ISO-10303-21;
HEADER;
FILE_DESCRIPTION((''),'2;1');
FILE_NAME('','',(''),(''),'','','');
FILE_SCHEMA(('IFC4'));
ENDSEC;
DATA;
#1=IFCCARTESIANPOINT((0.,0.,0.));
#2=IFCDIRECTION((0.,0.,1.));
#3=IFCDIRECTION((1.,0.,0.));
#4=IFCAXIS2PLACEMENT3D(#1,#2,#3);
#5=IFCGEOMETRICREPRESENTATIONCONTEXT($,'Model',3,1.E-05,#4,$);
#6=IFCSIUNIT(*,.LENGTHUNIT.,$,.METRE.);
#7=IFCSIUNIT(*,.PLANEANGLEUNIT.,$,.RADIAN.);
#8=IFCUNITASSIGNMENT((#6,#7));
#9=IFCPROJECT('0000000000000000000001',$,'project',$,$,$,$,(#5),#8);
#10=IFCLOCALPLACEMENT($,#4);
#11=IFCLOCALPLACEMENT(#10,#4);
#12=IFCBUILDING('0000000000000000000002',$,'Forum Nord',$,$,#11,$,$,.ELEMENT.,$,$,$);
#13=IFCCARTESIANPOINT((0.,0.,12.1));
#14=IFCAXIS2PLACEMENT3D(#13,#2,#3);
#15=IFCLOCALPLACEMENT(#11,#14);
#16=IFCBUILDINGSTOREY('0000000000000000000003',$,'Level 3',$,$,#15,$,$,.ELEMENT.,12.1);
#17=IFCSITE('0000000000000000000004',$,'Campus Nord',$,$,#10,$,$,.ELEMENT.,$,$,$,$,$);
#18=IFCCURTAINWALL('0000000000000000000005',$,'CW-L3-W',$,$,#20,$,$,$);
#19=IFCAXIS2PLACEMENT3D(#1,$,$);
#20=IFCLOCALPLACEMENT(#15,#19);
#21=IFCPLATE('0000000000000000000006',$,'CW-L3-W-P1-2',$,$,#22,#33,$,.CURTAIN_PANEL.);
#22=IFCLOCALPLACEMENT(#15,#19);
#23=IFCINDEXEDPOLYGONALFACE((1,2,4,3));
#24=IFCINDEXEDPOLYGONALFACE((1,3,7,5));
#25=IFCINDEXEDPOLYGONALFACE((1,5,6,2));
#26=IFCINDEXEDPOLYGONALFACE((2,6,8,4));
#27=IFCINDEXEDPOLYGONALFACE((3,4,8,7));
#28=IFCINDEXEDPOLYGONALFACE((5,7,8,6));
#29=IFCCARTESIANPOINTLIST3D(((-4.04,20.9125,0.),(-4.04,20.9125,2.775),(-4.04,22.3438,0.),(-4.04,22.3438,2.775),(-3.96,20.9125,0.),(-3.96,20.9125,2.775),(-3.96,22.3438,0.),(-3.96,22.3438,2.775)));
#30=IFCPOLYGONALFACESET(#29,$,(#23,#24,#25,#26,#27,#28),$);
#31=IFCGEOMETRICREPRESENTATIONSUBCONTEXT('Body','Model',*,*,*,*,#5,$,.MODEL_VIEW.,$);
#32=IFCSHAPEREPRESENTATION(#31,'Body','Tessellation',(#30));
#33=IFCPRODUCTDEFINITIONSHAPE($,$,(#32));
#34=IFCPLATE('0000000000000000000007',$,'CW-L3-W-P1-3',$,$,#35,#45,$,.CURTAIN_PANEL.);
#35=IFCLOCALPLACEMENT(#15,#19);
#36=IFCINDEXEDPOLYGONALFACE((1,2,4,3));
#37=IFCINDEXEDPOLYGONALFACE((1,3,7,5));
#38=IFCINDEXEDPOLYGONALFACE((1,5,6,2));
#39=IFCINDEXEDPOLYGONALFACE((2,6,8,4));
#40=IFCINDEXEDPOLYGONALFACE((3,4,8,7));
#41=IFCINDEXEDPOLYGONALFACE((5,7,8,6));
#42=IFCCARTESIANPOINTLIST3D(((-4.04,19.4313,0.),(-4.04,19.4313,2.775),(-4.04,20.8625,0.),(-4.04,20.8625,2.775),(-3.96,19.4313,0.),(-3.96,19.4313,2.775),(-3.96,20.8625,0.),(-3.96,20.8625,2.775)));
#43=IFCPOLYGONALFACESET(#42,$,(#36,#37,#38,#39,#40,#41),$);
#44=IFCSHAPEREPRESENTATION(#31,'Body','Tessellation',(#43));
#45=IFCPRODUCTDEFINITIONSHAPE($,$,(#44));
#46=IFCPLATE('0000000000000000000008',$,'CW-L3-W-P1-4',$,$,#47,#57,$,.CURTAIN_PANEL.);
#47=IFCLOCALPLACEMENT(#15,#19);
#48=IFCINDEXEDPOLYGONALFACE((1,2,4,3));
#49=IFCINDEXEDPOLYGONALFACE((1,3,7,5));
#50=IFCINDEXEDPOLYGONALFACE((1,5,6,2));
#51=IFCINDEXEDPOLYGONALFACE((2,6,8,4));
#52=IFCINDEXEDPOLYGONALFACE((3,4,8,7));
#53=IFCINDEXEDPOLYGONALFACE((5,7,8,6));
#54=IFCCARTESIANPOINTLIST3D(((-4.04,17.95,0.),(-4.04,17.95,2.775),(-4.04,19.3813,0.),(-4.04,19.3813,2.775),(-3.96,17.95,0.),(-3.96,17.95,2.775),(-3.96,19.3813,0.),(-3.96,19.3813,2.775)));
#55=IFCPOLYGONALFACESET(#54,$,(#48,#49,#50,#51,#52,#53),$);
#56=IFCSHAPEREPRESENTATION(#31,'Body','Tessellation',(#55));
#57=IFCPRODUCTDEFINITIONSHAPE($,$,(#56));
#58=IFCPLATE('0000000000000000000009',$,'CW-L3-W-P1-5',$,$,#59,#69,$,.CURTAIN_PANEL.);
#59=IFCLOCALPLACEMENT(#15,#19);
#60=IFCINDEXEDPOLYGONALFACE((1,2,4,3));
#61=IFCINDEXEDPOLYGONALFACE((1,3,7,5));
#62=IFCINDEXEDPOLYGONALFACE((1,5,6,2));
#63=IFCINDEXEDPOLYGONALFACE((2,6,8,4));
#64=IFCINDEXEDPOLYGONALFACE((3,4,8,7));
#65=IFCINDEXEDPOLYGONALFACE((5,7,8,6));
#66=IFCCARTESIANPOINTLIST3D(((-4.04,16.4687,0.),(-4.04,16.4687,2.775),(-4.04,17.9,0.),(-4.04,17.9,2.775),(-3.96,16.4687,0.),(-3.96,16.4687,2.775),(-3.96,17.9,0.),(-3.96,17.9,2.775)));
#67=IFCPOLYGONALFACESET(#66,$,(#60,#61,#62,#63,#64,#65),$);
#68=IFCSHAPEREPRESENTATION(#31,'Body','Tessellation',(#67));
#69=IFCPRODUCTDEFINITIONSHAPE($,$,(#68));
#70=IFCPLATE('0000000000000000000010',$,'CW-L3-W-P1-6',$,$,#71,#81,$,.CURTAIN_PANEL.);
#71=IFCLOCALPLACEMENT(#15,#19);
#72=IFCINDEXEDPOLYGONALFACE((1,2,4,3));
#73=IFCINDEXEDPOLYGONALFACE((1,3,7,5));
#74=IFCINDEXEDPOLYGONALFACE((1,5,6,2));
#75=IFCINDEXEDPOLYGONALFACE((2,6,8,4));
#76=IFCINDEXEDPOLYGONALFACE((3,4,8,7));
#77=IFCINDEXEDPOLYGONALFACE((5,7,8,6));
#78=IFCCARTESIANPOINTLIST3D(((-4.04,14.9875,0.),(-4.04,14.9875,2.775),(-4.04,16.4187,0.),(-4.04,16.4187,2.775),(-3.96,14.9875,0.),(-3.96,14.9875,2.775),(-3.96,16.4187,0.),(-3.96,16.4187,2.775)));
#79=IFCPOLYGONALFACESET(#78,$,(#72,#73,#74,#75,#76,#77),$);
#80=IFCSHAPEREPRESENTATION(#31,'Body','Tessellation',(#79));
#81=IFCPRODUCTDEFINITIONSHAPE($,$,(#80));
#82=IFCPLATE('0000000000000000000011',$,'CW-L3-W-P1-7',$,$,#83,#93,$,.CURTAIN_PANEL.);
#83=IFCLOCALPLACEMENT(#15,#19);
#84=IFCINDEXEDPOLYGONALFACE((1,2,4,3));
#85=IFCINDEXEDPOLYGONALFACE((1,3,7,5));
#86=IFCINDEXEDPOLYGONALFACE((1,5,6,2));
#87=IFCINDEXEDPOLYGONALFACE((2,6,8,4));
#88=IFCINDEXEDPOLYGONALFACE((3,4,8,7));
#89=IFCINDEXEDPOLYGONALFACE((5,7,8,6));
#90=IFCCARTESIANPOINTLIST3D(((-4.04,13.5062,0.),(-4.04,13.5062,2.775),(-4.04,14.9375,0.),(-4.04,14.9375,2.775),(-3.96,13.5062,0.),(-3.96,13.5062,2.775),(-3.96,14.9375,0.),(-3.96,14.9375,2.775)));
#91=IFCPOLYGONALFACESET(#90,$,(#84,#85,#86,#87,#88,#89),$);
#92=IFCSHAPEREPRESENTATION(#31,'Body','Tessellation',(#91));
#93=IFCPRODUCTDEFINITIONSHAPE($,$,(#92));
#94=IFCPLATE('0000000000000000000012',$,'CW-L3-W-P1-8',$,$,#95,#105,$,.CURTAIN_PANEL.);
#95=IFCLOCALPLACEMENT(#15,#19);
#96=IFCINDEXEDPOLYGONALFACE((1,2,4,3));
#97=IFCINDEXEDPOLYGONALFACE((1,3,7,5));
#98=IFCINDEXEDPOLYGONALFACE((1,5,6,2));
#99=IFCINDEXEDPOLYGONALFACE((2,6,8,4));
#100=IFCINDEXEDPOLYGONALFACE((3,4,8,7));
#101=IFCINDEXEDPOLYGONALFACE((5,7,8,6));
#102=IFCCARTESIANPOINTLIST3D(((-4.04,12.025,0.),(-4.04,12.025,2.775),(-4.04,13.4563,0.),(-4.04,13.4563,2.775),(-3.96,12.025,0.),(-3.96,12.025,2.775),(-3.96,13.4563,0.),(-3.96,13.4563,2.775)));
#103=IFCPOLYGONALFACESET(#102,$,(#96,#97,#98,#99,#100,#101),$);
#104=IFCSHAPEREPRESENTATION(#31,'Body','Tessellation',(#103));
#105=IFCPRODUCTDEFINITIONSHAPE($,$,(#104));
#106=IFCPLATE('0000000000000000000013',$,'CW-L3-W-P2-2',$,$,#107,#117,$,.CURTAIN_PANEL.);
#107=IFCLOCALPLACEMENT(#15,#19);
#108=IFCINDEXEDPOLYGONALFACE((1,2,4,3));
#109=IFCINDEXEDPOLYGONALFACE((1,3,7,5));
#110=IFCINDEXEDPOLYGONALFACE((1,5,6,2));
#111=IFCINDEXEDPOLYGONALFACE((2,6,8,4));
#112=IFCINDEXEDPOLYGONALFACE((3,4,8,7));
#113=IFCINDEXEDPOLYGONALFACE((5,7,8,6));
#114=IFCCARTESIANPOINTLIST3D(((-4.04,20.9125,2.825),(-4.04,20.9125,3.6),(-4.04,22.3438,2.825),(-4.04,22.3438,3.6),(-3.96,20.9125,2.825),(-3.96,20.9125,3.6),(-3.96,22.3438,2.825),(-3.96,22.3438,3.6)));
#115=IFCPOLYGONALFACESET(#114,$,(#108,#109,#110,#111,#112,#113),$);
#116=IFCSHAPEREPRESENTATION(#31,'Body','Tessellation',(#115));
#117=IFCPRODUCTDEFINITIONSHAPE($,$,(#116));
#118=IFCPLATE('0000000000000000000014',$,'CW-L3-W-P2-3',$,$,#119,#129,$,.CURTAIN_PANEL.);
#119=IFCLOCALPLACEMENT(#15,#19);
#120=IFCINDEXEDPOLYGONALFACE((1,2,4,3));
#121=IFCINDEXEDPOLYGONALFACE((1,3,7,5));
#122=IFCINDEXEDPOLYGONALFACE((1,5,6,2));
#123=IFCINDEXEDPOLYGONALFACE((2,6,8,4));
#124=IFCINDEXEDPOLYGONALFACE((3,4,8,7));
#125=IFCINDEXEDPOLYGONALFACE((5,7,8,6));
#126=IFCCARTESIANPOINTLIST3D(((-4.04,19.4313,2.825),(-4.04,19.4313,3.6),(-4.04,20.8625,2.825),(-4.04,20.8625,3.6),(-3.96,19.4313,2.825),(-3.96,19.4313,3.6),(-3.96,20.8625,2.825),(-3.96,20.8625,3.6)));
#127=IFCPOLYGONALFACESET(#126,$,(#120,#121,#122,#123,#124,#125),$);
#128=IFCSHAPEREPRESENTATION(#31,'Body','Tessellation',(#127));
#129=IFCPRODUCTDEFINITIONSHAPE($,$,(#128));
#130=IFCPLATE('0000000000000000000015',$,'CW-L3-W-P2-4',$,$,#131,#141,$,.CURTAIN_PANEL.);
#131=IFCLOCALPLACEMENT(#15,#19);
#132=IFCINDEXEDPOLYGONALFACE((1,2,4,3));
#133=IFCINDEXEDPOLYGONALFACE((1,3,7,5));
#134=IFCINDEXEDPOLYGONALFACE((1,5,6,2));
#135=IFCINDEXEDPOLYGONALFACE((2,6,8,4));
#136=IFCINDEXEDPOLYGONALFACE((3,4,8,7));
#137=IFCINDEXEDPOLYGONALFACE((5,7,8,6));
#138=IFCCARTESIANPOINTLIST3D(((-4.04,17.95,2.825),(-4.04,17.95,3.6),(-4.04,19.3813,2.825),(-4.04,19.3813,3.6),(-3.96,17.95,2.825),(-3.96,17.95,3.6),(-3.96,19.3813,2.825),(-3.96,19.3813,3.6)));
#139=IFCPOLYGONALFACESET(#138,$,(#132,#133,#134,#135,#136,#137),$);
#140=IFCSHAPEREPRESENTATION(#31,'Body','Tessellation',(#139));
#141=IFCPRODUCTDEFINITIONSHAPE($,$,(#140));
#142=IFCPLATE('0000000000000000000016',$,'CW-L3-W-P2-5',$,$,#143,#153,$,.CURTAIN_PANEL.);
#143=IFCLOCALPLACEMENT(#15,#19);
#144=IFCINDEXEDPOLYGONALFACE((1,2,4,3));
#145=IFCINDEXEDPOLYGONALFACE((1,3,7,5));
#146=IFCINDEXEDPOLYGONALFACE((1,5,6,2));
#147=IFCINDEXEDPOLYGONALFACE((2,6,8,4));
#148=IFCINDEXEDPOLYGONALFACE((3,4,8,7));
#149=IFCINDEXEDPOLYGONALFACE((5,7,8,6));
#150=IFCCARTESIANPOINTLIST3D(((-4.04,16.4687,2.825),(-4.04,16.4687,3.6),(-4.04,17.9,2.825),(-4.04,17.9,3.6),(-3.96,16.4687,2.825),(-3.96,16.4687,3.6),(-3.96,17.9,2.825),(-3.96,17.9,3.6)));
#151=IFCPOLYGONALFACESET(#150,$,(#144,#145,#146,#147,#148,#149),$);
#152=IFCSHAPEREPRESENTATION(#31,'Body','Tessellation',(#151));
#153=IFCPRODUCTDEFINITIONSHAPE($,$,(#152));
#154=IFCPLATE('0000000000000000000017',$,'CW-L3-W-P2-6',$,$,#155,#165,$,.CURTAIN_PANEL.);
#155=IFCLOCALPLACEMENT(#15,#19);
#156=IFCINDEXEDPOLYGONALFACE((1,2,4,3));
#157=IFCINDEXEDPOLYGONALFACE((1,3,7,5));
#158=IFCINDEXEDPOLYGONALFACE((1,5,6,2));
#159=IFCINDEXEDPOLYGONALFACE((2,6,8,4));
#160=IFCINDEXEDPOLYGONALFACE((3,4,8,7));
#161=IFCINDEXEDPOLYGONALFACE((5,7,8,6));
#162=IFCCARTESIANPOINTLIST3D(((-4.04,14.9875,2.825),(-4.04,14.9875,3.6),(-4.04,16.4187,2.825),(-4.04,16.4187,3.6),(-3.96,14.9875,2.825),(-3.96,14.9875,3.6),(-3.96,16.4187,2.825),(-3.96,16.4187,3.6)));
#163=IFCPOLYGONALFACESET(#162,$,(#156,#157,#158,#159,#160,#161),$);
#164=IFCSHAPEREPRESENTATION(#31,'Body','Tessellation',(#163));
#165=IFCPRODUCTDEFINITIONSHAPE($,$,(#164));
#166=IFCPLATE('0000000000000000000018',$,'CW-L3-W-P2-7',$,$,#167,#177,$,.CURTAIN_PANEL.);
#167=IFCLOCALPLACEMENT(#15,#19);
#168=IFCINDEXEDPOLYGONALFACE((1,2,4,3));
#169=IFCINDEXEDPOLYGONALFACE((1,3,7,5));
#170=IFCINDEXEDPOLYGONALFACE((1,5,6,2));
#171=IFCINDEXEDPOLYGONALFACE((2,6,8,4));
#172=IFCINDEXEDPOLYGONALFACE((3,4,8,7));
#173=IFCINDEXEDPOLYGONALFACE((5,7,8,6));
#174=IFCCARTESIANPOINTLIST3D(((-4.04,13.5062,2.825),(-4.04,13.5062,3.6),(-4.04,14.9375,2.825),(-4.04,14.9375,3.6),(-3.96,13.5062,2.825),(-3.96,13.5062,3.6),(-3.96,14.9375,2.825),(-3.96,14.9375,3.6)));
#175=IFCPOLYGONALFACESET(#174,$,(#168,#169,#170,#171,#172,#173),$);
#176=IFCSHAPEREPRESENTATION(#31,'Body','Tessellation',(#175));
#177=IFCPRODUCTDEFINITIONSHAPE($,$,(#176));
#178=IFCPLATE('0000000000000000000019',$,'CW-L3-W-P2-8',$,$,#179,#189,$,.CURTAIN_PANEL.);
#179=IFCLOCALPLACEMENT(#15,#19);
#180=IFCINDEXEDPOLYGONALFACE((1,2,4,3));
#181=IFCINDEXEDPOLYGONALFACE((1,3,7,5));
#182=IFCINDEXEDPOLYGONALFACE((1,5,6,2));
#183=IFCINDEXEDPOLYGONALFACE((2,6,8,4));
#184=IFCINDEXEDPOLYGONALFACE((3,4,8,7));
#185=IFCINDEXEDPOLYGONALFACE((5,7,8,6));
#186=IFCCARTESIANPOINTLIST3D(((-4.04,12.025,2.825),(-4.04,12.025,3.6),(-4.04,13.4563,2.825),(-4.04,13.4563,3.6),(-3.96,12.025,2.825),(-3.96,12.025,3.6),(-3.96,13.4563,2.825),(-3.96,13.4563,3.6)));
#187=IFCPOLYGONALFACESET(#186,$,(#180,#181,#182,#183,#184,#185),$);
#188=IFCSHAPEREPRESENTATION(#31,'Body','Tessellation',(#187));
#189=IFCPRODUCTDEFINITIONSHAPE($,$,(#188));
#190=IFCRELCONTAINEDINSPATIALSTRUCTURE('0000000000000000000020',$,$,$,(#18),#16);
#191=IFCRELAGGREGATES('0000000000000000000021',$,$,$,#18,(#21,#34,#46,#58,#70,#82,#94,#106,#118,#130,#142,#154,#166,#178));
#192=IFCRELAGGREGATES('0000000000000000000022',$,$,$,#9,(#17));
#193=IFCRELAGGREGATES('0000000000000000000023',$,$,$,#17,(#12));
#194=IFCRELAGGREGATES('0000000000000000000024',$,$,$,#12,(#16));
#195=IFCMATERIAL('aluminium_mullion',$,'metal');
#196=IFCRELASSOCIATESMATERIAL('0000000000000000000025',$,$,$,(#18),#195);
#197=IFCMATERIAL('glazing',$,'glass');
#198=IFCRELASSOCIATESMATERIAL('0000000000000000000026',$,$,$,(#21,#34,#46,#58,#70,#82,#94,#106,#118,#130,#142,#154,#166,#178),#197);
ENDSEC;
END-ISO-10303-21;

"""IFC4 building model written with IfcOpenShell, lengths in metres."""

from ifc_helpers import new_model, si_unit, frame, frame_2d, origin_with_axes, place, context, subcontext, project, spatial, rectangle, extrude, material, element, aggregate, save


model = new_model("IFC4")

# Units and contexts
model_context = context("Model", 3, precision=1e-05, world=origin_with_axes())
body_context = subcontext(model_context, "Body", "Model", "MODEL_VIEW")
ifc_project = project(units=[si_unit("LENGTHUNIT", "METRE"), si_unit("PLANEANGLEUNIT", "RADIAN")], contexts=[model_context])

# Site, building, storey
site_placement = place(None, origin_with_axes())
site = spatial("IfcSite", under=ifc_project, at=site_placement, Name="Campus Nord", CompositionType="ELEMENT")
building_placement = place(site_placement, origin_with_axes())
building = spatial("IfcBuilding", under=site, at=building_placement, Name="Forum Nord", CompositionType="ELEMENT")
storey_placement = place(building_placement, frame((0.0, 0.0, 12.1), z_axis=(0.0, 0.0, 1.0), x_axis=(1.0, 0.0, 0.0)))
storey = spatial("IfcBuildingStorey", under=building, at=storey_placement, Name="Level 3", CompositionType="ELEMENT", Elevation=12.1)

# Curtain wall, plates
ifc_material_1 = material(Name="aluminium_mullion", Category="metal")
curtain_wall_placement = place(storey_placement, origin_with_axes())
curtain_wall = element("IfcCurtainWall", 1, at=curtain_wall_placement, inside=storey, material=ifc_material_1, Name="CW-L3-W")
ifc_material_2 = material(Name="glazing", Category="glass")
plate_1_placement = place(storey_placement, frame((-4.0, 22.3438, 0.0), z_axis=(0.0, 0.0, 1.0), x_axis=(0.0, -1.0, 0.0)))
plate_1 = element("IfcPlate", 2, at=plate_1_placement, material=ifc_material_2, Name="CW-L3-W-P1-2", PredefinedType="CURTAIN_PANEL", context=body_context, shape_type="SweptSolid", body=[
    extrude(rectangle(XDim=1.4312, YDim=0.08, at=frame_2d((0.7156, 0.0), x_axis=(1.0, 0.0))), origin_with_axes(), (0.0, 0.0, 1.0), 2.775),
])
plate_2_placement = place(storey_placement, frame((-4.0, 20.8625, 0.0), z_axis=(0.0, 0.0, 1.0), x_axis=(0.0, -1.0, 0.0)))
plate_2 = element("IfcPlate", 3, at=plate_2_placement, material=ifc_material_2, Name="CW-L3-W-P1-3", PredefinedType="CURTAIN_PANEL", context=body_context, shape_type="SweptSolid", body=[
    extrude(rectangle(XDim=1.4312, YDim=0.08, at=frame_2d((0.7156, 0.0), x_axis=(1.0, 0.0))), origin_with_axes(), (0.0, 0.0, 1.0), 2.775),
])
plate_3_placement = place(storey_placement, frame((-4.0, 19.3813, 0.0), z_axis=(0.0, 0.0, 1.0), x_axis=(0.0, -1.0, 0.0)))
plate_3 = element("IfcPlate", 4, at=plate_3_placement, material=ifc_material_2, Name="CW-L3-W-P1-4", PredefinedType="CURTAIN_PANEL", context=body_context, shape_type="SweptSolid", body=[
    extrude(rectangle(XDim=1.4312, YDim=0.08, at=frame_2d((0.7156, 0.0), x_axis=(1.0, 0.0))), origin_with_axes(), (0.0, 0.0, 1.0), 2.775),
])
plate_4_placement = place(storey_placement, frame((-4.0, 17.9, 0.0), z_axis=(0.0, 0.0, 1.0), x_axis=(0.0, -1.0, 0.0)))
plate_4 = element("IfcPlate", 5, at=plate_4_placement, material=ifc_material_2, Name="CW-L3-W-P1-5", PredefinedType="CURTAIN_PANEL", context=body_context, shape_type="SweptSolid", body=[
    extrude(rectangle(XDim=1.4312, YDim=0.08, at=frame_2d((0.7156, 0.0), x_axis=(1.0, 0.0))), origin_with_axes(), (0.0, 0.0, 1.0), 2.775),
])
plate_5_placement = place(storey_placement, frame((-4.0, 16.4187, 0.0), z_axis=(0.0, 0.0, 1.0), x_axis=(0.0, -1.0, 0.0)))
plate_5 = element("IfcPlate", 6, at=plate_5_placement, material=ifc_material_2, Name="CW-L3-W-P1-6", PredefinedType="CURTAIN_PANEL", context=body_context, shape_type="SweptSolid", body=[
    extrude(rectangle(XDim=1.4312, YDim=0.08, at=frame_2d((0.7156, 0.0), x_axis=(1.0, 0.0))), origin_with_axes(), (0.0, 0.0, 1.0), 2.775),
])
plate_6_placement = place(storey_placement, frame((-4.0, 14.9375, 0.0), z_axis=(0.0, 0.0, 1.0), x_axis=(0.0, -1.0, 0.0)))
plate_6 = element("IfcPlate", 7, at=plate_6_placement, material=ifc_material_2, Name="CW-L3-W-P1-7", PredefinedType="CURTAIN_PANEL", context=body_context, shape_type="SweptSolid", body=[
    extrude(rectangle(XDim=1.4312, YDim=0.08, at=frame_2d((0.7156, 0.0), x_axis=(1.0, 0.0))), origin_with_axes(), (0.0, 0.0, 1.0), 2.775),
])
plate_7_placement = place(storey_placement, frame((-4.0, 13.4563, 0.0), z_axis=(0.0, 0.0, 1.0), x_axis=(0.0, -1.0, 0.0)))
plate_7 = element("IfcPlate", 8, at=plate_7_placement, material=ifc_material_2, Name="CW-L3-W-P1-8", PredefinedType="CURTAIN_PANEL", context=body_context, shape_type="SweptSolid", body=[
    extrude(rectangle(XDim=1.4312, YDim=0.08, at=frame_2d((0.7156, 0.0), x_axis=(1.0, 0.0))), origin_with_axes(), (0.0, 0.0, 1.0), 2.775),
])
plate_8_placement = place(storey_placement, frame((-4.0, 22.3438, 2.825), z_axis=(0.0, 0.0, 1.0), x_axis=(0.0, -1.0, 0.0)))
plate_8 = element("IfcPlate", 9, at=plate_8_placement, material=ifc_material_2, Name="CW-L3-W-P2-2", PredefinedType="CURTAIN_PANEL", context=body_context, shape_type="SweptSolid", body=[
    extrude(rectangle(XDim=1.4312, YDim=0.08, at=frame_2d((0.7156, 0.0), x_axis=(1.0, 0.0))), origin_with_axes(), (0.0, 0.0, 1.0), 0.775),
])
plate_9_placement = place(storey_placement, frame((-4.0, 20.8625, 2.825), z_axis=(0.0, 0.0, 1.0), x_axis=(0.0, -1.0, 0.0)))
plate_9 = element("IfcPlate", 10, at=plate_9_placement, material=ifc_material_2, Name="CW-L3-W-P2-3", PredefinedType="CURTAIN_PANEL", context=body_context, shape_type="SweptSolid", body=[
    extrude(rectangle(XDim=1.4312, YDim=0.08, at=frame_2d((0.7156, 0.0), x_axis=(1.0, 0.0))), origin_with_axes(), (0.0, 0.0, 1.0), 0.775),
])
plate_10_placement = place(storey_placement, frame((-4.0, 19.3813, 2.825), z_axis=(0.0, 0.0, 1.0), x_axis=(0.0, -1.0, 0.0)))
plate_10 = element("IfcPlate", 11, at=plate_10_placement, material=ifc_material_2, Name="CW-L3-W-P2-4", PredefinedType="CURTAIN_PANEL", context=body_context, shape_type="SweptSolid", body=[
    extrude(rectangle(XDim=1.4312, YDim=0.08, at=frame_2d((0.7156, 0.0), x_axis=(1.0, 0.0))), origin_with_axes(), (0.0, 0.0, 1.0), 0.775),
])
plate_11_placement = place(storey_placement, frame((-4.0, 17.9, 2.825), z_axis=(0.0, 0.0, 1.0), x_axis=(0.0, -1.0, 0.0)))
plate_11 = element("IfcPlate", 12, at=plate_11_placement, material=ifc_material_2, Name="CW-L3-W-P2-5", PredefinedType="CURTAIN_PANEL", context=body_context, shape_type="SweptSolid", body=[
    extrude(rectangle(XDim=1.4312, YDim=0.08, at=frame_2d((0.7156, 0.0), x_axis=(1.0, 0.0))), origin_with_axes(), (0.0, 0.0, 1.0), 0.775),
])
plate_12_placement = place(storey_placement, frame((-4.0, 16.4187, 2.825), z_axis=(0.0, 0.0, 1.0), x_axis=(0.0, -1.0, 0.0)))
plate_12 = element("IfcPlate", 13, at=plate_12_placement, material=ifc_material_2, Name="CW-L3-W-P2-6", PredefinedType="CURTAIN_PANEL", context=body_context, shape_type="SweptSolid", body=[
    extrude(rectangle(XDim=1.4312, YDim=0.08, at=frame_2d((0.7156, 0.0), x_axis=(1.0, 0.0))), origin_with_axes(), (0.0, 0.0, 1.0), 0.775),
])
plate_13_placement = place(storey_placement, frame((-4.0, 14.9375, 2.825), z_axis=(0.0, 0.0, 1.0), x_axis=(0.0, -1.0, 0.0)))
plate_13 = element("IfcPlate", 14, at=plate_13_placement, material=ifc_material_2, Name="CW-L3-W-P2-7", PredefinedType="CURTAIN_PANEL", context=body_context, shape_type="SweptSolid", body=[
    extrude(rectangle(XDim=1.4312, YDim=0.08, at=frame_2d((0.7156, 0.0), x_axis=(1.0, 0.0))), origin_with_axes(), (0.0, 0.0, 1.0), 0.775),
])
plate_14_placement = place(storey_placement, frame((-4.0, 13.4563, 2.825), z_axis=(0.0, 0.0, 1.0), x_axis=(0.0, -1.0, 0.0)))
plate_14 = element("IfcPlate", 15, at=plate_14_placement, material=ifc_material_2, Name="CW-L3-W-P2-8", PredefinedType="CURTAIN_PANEL", context=body_context, shape_type="SweptSolid", body=[
    extrude(rectangle(XDim=1.4312, YDim=0.08, at=frame_2d((0.7156, 0.0), x_axis=(1.0, 0.0))), origin_with_axes(), (0.0, 0.0, 1.0), 0.775),
])
aggregate(curtain_wall, [plate_1, plate_2, plate_3, plate_4, plate_5, plate_6, plate_7, plate_8, plate_9, plate_10, plate_11, plate_12, plate_13, plate_14])

save(model, "model.ifc")
